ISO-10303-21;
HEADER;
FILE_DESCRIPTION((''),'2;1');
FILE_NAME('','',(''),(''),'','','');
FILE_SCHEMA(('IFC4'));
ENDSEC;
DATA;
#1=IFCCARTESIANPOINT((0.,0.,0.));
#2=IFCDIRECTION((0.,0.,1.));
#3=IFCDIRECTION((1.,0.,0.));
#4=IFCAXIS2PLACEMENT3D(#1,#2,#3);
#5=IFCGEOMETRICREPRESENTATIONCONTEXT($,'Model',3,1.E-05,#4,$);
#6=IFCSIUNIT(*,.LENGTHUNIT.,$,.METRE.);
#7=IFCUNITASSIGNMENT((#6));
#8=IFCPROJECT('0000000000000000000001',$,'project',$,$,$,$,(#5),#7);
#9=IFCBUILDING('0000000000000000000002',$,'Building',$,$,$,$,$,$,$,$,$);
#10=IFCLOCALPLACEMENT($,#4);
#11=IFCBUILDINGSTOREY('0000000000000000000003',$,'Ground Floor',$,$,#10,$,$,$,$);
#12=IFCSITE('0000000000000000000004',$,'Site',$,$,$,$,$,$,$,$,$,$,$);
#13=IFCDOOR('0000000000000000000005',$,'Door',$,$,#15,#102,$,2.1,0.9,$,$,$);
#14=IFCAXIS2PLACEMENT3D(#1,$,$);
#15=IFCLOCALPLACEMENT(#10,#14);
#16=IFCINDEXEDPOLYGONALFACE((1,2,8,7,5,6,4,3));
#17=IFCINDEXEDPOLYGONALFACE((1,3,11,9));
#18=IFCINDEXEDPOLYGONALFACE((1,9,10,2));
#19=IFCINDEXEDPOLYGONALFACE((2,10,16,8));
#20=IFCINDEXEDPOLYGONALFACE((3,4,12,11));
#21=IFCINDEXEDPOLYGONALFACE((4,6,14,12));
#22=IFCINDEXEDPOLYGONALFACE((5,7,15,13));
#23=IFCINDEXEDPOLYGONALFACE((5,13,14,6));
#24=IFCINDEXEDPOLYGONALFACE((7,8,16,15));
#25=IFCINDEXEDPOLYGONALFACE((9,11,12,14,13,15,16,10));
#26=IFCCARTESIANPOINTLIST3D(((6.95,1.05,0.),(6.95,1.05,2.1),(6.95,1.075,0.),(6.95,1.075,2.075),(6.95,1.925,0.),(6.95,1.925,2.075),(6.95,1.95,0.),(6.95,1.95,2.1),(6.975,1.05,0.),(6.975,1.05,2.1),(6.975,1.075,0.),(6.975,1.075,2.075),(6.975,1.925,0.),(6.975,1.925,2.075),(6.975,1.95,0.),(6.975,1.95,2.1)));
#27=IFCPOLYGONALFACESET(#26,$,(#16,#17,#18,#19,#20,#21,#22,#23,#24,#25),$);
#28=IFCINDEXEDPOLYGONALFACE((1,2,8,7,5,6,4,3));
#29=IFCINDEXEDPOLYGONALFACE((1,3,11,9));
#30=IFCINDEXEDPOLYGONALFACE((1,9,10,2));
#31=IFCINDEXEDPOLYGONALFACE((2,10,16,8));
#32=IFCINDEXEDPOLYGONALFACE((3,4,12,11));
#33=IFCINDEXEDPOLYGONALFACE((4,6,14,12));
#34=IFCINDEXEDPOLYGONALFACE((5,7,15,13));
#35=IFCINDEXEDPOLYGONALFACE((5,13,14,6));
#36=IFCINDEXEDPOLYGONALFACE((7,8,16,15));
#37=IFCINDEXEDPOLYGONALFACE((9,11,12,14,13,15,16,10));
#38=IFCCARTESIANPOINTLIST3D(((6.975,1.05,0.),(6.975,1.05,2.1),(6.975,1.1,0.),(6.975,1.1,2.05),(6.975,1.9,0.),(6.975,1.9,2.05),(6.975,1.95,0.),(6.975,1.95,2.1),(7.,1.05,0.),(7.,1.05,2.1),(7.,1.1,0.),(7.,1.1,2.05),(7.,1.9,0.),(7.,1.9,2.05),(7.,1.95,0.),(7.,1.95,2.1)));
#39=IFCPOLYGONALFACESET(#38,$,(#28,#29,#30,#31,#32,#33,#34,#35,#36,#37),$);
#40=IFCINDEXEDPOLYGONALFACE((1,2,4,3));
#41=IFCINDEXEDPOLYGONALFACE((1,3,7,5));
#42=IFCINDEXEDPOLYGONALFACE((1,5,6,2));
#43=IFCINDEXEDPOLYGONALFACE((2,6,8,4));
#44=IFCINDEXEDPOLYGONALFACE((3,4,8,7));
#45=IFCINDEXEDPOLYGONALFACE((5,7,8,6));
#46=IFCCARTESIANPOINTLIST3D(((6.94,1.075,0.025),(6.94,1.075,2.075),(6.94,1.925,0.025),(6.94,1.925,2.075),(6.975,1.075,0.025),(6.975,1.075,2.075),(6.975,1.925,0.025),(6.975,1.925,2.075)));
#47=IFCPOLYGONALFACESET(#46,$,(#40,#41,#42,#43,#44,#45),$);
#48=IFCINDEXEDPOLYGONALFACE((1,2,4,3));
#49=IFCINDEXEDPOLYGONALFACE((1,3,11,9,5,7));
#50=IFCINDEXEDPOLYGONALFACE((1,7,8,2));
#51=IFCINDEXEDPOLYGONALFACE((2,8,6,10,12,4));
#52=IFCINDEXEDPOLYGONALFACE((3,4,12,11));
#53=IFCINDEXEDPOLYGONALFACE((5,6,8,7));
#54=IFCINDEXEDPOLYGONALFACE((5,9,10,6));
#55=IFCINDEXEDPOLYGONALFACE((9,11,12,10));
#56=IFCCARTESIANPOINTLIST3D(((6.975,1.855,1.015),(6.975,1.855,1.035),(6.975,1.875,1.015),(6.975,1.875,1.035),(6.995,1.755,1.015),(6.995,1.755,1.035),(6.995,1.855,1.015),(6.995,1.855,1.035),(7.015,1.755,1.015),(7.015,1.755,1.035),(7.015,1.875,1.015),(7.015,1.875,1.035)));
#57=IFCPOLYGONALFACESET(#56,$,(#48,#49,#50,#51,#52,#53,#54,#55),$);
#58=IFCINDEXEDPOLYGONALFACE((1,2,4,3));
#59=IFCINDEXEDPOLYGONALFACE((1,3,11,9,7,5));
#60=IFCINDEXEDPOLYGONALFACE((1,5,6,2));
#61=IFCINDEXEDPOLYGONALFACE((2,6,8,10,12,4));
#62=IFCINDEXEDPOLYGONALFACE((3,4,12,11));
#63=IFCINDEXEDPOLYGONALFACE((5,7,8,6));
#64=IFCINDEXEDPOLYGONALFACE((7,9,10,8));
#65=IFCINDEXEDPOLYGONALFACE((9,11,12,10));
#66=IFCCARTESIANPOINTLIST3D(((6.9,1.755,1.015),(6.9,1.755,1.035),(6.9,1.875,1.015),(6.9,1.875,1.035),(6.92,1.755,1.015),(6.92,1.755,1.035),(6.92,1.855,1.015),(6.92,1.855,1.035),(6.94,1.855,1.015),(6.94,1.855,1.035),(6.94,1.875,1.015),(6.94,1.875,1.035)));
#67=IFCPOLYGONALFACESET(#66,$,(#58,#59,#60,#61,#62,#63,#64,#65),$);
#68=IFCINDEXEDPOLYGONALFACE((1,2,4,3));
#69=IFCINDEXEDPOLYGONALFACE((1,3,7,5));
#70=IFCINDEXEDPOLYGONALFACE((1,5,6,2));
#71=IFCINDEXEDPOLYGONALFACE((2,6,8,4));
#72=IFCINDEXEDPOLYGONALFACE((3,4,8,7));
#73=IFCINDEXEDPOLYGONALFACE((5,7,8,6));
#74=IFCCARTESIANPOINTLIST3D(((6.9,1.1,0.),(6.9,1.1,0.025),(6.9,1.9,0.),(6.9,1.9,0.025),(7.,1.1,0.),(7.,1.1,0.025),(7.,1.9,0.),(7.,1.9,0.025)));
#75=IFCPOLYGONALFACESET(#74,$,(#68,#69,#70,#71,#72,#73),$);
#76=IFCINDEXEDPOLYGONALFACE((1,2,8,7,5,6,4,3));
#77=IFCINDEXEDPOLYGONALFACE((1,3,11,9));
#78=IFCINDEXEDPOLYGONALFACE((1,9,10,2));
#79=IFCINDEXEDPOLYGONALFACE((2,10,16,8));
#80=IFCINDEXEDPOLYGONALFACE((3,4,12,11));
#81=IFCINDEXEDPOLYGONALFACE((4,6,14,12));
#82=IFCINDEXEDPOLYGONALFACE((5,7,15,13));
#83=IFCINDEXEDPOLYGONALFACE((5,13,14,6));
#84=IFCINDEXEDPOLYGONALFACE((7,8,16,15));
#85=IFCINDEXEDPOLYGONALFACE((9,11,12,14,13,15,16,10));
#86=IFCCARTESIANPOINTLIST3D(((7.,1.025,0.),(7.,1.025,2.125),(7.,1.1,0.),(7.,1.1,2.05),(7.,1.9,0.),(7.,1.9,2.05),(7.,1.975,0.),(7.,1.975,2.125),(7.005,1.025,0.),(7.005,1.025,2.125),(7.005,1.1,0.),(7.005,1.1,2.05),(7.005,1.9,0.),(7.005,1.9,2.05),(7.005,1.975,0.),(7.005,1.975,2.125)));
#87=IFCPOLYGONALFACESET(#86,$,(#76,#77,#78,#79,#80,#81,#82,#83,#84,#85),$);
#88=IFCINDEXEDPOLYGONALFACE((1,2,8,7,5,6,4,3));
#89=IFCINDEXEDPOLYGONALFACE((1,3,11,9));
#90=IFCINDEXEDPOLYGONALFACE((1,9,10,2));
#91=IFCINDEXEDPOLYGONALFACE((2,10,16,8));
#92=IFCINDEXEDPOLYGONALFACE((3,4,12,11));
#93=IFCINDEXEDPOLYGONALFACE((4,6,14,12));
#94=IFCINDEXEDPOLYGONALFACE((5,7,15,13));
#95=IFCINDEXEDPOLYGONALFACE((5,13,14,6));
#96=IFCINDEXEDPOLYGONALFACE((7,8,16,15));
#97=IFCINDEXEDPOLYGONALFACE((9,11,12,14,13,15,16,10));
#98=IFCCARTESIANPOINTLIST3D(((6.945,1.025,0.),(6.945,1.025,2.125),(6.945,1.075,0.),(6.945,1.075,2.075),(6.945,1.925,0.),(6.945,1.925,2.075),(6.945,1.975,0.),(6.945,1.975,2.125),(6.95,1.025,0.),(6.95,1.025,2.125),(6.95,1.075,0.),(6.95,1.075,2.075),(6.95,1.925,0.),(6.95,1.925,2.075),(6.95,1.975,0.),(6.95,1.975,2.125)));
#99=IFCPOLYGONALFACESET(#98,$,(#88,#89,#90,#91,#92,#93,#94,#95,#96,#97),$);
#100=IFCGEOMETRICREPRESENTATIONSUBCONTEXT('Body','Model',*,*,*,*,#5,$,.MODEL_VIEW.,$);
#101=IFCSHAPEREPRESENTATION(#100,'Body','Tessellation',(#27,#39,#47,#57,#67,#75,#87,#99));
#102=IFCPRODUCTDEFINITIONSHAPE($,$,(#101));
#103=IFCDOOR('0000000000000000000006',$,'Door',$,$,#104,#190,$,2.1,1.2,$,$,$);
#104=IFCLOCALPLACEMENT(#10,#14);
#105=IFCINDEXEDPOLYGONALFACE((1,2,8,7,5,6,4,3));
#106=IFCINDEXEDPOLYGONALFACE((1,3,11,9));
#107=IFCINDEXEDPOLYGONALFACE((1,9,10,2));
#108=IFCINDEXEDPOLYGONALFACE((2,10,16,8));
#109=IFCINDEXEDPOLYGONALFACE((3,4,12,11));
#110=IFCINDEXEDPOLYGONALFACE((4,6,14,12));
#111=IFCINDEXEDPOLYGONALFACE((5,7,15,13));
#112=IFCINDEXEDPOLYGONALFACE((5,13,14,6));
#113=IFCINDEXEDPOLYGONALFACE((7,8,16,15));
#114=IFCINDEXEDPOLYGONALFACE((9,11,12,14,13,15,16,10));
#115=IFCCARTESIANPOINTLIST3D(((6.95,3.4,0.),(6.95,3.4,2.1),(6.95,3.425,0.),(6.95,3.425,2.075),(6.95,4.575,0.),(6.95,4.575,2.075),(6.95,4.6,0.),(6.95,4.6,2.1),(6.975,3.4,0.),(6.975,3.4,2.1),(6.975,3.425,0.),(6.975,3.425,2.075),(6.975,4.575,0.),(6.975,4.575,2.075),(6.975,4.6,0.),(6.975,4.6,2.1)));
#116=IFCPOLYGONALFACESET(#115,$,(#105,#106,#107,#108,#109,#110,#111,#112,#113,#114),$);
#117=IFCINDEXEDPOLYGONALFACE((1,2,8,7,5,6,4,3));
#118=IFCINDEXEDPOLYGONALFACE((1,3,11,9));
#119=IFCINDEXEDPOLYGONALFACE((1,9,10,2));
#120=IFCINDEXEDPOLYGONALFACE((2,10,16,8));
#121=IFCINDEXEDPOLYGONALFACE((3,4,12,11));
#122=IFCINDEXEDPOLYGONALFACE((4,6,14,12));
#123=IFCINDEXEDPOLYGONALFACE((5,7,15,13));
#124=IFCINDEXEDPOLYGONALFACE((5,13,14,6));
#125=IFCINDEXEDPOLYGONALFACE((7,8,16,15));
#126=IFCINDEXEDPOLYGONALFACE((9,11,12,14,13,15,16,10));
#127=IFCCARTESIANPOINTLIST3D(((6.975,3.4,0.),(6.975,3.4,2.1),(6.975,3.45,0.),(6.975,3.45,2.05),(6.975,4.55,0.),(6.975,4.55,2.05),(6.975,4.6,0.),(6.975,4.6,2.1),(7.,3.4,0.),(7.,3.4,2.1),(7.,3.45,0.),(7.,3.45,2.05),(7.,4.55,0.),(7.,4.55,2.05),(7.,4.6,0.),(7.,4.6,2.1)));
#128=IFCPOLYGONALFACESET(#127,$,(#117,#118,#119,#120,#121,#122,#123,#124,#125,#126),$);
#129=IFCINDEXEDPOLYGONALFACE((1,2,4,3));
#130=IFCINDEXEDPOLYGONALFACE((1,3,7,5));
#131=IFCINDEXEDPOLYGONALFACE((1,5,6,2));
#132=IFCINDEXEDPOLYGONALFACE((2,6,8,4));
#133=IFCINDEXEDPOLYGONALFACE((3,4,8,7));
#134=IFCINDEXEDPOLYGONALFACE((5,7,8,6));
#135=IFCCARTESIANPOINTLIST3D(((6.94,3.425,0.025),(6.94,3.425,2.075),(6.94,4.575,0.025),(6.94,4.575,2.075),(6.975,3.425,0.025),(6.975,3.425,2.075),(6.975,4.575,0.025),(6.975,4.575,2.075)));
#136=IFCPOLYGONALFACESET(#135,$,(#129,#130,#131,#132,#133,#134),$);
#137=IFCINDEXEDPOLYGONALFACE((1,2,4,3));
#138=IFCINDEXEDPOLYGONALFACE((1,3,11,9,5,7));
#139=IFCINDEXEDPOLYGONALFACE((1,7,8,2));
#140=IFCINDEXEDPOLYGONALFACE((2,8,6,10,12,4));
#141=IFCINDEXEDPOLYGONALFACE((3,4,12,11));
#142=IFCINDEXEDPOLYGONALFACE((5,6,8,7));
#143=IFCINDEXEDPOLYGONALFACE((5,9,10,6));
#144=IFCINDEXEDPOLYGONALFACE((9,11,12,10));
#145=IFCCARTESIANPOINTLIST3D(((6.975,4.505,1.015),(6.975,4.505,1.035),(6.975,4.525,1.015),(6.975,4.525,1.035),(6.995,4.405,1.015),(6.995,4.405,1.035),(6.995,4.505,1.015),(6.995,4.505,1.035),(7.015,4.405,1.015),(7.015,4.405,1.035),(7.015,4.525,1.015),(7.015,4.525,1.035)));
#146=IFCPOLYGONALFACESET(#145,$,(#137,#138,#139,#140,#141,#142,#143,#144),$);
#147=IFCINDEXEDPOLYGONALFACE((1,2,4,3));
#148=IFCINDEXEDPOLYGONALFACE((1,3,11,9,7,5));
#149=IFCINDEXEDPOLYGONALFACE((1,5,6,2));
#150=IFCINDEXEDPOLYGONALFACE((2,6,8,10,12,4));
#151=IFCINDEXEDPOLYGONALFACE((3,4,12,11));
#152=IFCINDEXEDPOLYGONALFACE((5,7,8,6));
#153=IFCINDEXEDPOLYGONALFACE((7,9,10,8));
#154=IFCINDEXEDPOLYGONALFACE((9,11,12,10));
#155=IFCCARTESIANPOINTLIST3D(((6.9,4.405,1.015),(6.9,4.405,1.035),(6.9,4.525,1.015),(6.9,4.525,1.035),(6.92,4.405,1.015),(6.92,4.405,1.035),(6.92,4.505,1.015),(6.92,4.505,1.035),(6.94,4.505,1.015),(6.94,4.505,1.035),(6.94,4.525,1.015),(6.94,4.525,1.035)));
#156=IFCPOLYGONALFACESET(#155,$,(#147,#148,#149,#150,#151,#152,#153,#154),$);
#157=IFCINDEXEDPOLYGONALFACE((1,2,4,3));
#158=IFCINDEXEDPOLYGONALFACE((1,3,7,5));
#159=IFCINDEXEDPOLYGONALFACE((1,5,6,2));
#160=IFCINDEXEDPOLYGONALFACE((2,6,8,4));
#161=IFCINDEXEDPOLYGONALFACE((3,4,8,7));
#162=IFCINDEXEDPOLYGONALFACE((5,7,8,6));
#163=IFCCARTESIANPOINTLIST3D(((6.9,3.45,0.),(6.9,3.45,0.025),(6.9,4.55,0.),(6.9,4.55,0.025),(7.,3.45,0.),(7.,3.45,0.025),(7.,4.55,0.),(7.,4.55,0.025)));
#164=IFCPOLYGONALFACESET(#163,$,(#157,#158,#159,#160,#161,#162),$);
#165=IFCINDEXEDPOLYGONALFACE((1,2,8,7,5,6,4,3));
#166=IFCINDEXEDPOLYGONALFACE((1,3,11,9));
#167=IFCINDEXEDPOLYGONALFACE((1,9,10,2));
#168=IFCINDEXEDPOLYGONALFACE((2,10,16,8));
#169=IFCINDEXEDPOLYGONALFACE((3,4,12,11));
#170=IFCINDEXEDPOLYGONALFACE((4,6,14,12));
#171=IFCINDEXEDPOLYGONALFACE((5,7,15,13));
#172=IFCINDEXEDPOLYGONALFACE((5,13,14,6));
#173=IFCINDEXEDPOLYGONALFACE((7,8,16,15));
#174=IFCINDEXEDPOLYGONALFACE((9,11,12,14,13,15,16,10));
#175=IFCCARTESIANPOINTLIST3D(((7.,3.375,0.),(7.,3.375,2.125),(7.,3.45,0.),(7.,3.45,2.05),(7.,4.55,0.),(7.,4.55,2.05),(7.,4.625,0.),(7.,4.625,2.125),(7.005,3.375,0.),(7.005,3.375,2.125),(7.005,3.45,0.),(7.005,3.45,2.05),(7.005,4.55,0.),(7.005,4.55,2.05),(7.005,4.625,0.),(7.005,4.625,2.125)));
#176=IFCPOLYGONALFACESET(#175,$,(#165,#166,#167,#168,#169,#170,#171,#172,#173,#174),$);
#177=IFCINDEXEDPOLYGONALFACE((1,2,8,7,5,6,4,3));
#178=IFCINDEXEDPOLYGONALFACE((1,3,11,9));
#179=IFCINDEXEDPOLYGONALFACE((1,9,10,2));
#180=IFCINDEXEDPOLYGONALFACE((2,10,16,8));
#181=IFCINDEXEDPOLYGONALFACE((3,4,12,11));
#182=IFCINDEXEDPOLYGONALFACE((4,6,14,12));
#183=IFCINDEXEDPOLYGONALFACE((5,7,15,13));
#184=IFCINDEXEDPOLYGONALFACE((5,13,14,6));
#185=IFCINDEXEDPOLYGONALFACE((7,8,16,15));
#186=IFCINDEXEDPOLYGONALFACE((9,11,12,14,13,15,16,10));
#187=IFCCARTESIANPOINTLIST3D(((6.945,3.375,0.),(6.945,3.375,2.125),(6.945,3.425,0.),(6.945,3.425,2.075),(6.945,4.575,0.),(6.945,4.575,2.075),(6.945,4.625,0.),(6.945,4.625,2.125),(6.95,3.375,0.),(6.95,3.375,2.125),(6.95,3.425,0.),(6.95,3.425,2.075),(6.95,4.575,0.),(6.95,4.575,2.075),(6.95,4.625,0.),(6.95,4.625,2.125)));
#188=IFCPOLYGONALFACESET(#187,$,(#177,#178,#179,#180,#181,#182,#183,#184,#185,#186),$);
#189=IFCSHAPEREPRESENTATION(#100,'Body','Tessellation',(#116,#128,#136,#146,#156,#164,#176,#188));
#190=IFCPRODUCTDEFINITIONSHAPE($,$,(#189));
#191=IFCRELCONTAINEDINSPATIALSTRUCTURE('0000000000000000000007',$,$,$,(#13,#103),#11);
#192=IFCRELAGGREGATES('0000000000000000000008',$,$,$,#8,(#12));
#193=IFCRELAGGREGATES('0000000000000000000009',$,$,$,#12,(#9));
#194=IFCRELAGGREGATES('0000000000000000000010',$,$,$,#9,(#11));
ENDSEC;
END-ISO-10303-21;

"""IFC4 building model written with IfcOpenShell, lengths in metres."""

from ifc_helpers import new_model, si_unit, frame, origin_with_axes, place, context, subcontext, project, spatial, line, indexed_curve, outline, extrude, element, save


model = new_model("IFC4")

# Units and contexts
model_context = context("Model", 3, precision=1e-05, world=origin_with_axes())
body_context = subcontext(model_context, "Body", "Model", "MODEL_VIEW")
ifc_project = project(units=[si_unit("LENGTHUNIT", "METRE")], contexts=[model_context])

# Site, building, storey
site = spatial("IfcSite", under=ifc_project, Name="Site")
building = spatial("IfcBuilding", under=site, Name="Building")
storey_placement = place(None, origin_with_axes())
storey = spatial("IfcBuildingStorey", under=building, at=storey_placement, Name="Ground Floor")

# Doors
door_1_placement = place(storey_placement, frame((7.0, 1.05, 0.0), z_axis=(0.0, 0.0, 1.0), x_axis=(0.0, 1.0, 0.0)))
element("IfcDoor", 1, at=door_1_placement, inside=storey, Name="Door", OverallHeight=2.1, OverallWidth=0.9, context=body_context, shape_type="SweptSolid", body=[
    extrude(outline(indexed_curve([(0.0, 0.0), (0.0, 2.1), (0.9, 2.1), (0.9, 0.0), (0.875, 0.0), (0.875, 2.075), (0.025, 2.075), (0.025, 0.0)], segments=[line(1, 2, 3, 4, 5, 6, 7, 8, 1)])), frame((0.0, 0.025, 0.0), z_axis=(0.0, -1.0, 0.0), x_axis=(1.0, 0.0, 0.0)), (0.0, 0.0, -1.0), 0.025),
    extrude(outline(indexed_curve([(0.0, 0.0), (0.0, 2.1), (0.9, 2.1), (0.9, 0.0), (0.85, 0.0), (0.85, 2.05), (0.05, 2.05), (0.05, 0.0)], segments=[line(1, 2, 3, 4, 5, 6, 7, 8, 1)])), frame((0.0, 0.0, 0.0), z_axis=(0.0, -1.0, 0.0), x_axis=(1.0, 0.0, 0.0)), (0.0, 0.0, -1.0), 0.025),
    extrude(outline(indexed_curve([(0.0, 0.0), (0.85, 0.0), (0.85, 0.035), (0.0, 0.035)], segments=[line(1, 2, 3, 4, 1)])), frame((0.025, 0.025, 0.025), z_axis=(0.0, 0.0, 1.0), x_axis=(1.0, 0.0, 0.0)), (0.0, 0.0, 1.0), 2.05),
    extrude(outline(indexed_curve([(0.0, 0.0), (0.0, -0.04), (-0.12, -0.04), (-0.12, -0.02), (-0.02, -0.02), (-0.02, 0.0)], segments=[line(1, 2, 3, 4, 5, 6, 1)])), frame((0.825, 0.025, 1.015), z_axis=(0.0, 0.0, 1.0), x_axis=(1.0, 0.0, 0.0)), (0.0, 0.0, 1.0), 0.02),
    extrude(outline(indexed_curve([(0.0, 0.0), (0.0, 0.04), (-0.12, 0.04), (-0.12, 0.02), (-0.02, 0.02), (-0.02, 0.0)], segments=[line(1, 2, 3, 4, 5, 6, 1)])), frame((0.825, 0.06, 1.015), z_axis=(0.0, 0.0, 1.0), x_axis=(1.0, 0.0, 0.0)), (0.0, 0.0, 1.0), 0.02),
    extrude(outline(indexed_curve([(0.0, 0.0), (0.8, 0.0), (0.8, 0.1), (0.0, 0.1)], segments=[line(1, 2, 3, 4, 1)])), frame((0.05, 0.0, 0.0), z_axis=(0.0, 0.0, 1.0), x_axis=(1.0, 0.0, 0.0)), (0.0, 0.0, 1.0), 0.025),
    extrude(outline(indexed_curve([(0.0, 0.0), (0.0, 2.125), (0.95, 2.125), (0.95, 0.0), (0.875, 0.0), (0.875, 2.05), (0.075, 2.05), (0.075, 0.0)], segments=[line(1, 2, 3, 4, 5, 6, 7, 8, 1)])), frame((-0.025, -0.005, 0.0), z_axis=(0.0, -1.0, 0.0), x_axis=(1.0, 0.0, 0.0)), (0.0, 0.0, -1.0), 0.005),
    extrude(outline(indexed_curve([(0.0, 0.0), (0.0, 2.125), (0.95, 2.125), (0.95, 0.0), (0.9, 0.0), (0.9, 2.075), (0.05, 2.075), (0.05, 0.0)], segments=[line(1, 2, 3, 4, 5, 6, 7, 8, 1)])), frame((-0.025, 0.05, 0.0), z_axis=(0.0, -1.0, 0.0), x_axis=(1.0, 0.0, 0.0)), (0.0, 0.0, -1.0), 0.005),
])
door_2_placement = place(storey_placement, frame((7.0, 3.4, 0.0), z_axis=(0.0, 0.0, 1.0), x_axis=(0.0, 1.0, 0.0)))
element("IfcDoor", 2, at=door_2_placement, inside=storey, Name="Door", OverallHeight=2.1, OverallWidth=1.2, context=body_context, shape_type="SweptSolid", body=[
    extrude(outline(indexed_curve([(0.0, 0.0), (0.0, 2.1), (1.2, 2.1), (1.2, 0.0), (1.175, 0.0), (1.175, 2.075), (0.025, 2.075), (0.025, 0.0)], segments=[line(1, 2, 3, 4, 5, 6, 7, 8, 1)])), frame((0.0, 0.025, 0.0), z_axis=(0.0, -1.0, 0.0), x_axis=(1.0, 0.0, 0.0)), (0.0, 0.0, -1.0), 0.025),
    extrude(outline(indexed_curve([(0.0, 0.0), (0.0, 2.1), (1.2, 2.1), (1.2, 0.0), (1.15, 0.0), (1.15, 2.05), (0.05, 2.05), (0.05, 0.0)], segments=[line(1, 2, 3, 4, 5, 6, 7, 8, 1)])), frame((0.0, 0.0, 0.0), z_axis=(0.0, -1.0, 0.0), x_axis=(1.0, 0.0, 0.0)), (0.0, 0.0, -1.0), 0.025),
    extrude(outline(indexed_curve([(0.0, 0.0), (1.15, 0.0), (1.15, 0.035), (0.0, 0.035)], segments=[line(1, 2, 3, 4, 1)])), frame((0.025, 0.025, 0.025), z_axis=(0.0, 0.0, 1.0), x_axis=(1.0, 0.0, 0.0)), (0.0, 0.0, 1.0), 2.05),
    extrude(outline(indexed_curve([(0.0, 0.0), (0.0, -0.04), (-0.12, -0.04), (-0.12, -0.02), (-0.02, -0.02), (-0.02, 0.0)], segments=[line(1, 2, 3, 4, 5, 6, 1)])), frame((1.125, 0.025, 1.015), z_axis=(0.0, 0.0, 1.0), x_axis=(1.0, 0.0, 0.0)), (0.0, 0.0, 1.0), 0.02),
    extrude(outline(indexed_curve([(0.0, 0.0), (0.0, 0.04), (-0.12, 0.04), (-0.12, 0.02), (-0.02, 0.02), (-0.02, 0.0)], segments=[line(1, 2, 3, 4, 5, 6, 1)])), frame((1.125, 0.06, 1.015), z_axis=(0.0, 0.0, 1.0), x_axis=(1.0, 0.0, 0.0)), (0.0, 0.0, 1.0), 0.02),
    extrude(outline(indexed_curve([(0.0, 0.0), (1.1, 0.0), (1.1, 0.1), (0.0, 0.1)], segments=[line(1, 2, 3, 4, 1)])), frame((0.05, 0.0, 0.0), z_axis=(0.0, 0.0, 1.0), x_axis=(1.0, 0.0, 0.0)), (0.0, 0.0, 1.0), 0.025),
    extrude(outline(indexed_curve([(0.0, 0.0), (0.0, 2.125), (1.25, 2.125), (1.25, 0.0), (1.175, 0.0), (1.175, 2.05), (0.075, 2.05), (0.075, 0.0)], segments=[line(1, 2, 3, 4, 5, 6, 7, 8, 1)])), frame((-0.025, -0.005, 0.0), z_axis=(0.0, -1.0, 0.0), x_axis=(1.0, 0.0, 0.0)), (0.0, 0.0, -1.0), 0.005),
    extrude(outline(indexed_curve([(0.0, 0.0), (0.0, 2.125), (1.25, 2.125), (1.25, 0.0), (1.2, 0.0), (1.2, 2.075), (0.05, 2.075), (0.05, 0.0)], segments=[line(1, 2, 3, 4, 5, 6, 7, 8, 1)])), frame((-0.025, 0.05, 0.0), z_axis=(0.0, -1.0, 0.0), x_axis=(1.0, 0.0, 0.0)), (0.0, 0.0, -1.0), 0.005),
])

save(model, "model.ifc")
